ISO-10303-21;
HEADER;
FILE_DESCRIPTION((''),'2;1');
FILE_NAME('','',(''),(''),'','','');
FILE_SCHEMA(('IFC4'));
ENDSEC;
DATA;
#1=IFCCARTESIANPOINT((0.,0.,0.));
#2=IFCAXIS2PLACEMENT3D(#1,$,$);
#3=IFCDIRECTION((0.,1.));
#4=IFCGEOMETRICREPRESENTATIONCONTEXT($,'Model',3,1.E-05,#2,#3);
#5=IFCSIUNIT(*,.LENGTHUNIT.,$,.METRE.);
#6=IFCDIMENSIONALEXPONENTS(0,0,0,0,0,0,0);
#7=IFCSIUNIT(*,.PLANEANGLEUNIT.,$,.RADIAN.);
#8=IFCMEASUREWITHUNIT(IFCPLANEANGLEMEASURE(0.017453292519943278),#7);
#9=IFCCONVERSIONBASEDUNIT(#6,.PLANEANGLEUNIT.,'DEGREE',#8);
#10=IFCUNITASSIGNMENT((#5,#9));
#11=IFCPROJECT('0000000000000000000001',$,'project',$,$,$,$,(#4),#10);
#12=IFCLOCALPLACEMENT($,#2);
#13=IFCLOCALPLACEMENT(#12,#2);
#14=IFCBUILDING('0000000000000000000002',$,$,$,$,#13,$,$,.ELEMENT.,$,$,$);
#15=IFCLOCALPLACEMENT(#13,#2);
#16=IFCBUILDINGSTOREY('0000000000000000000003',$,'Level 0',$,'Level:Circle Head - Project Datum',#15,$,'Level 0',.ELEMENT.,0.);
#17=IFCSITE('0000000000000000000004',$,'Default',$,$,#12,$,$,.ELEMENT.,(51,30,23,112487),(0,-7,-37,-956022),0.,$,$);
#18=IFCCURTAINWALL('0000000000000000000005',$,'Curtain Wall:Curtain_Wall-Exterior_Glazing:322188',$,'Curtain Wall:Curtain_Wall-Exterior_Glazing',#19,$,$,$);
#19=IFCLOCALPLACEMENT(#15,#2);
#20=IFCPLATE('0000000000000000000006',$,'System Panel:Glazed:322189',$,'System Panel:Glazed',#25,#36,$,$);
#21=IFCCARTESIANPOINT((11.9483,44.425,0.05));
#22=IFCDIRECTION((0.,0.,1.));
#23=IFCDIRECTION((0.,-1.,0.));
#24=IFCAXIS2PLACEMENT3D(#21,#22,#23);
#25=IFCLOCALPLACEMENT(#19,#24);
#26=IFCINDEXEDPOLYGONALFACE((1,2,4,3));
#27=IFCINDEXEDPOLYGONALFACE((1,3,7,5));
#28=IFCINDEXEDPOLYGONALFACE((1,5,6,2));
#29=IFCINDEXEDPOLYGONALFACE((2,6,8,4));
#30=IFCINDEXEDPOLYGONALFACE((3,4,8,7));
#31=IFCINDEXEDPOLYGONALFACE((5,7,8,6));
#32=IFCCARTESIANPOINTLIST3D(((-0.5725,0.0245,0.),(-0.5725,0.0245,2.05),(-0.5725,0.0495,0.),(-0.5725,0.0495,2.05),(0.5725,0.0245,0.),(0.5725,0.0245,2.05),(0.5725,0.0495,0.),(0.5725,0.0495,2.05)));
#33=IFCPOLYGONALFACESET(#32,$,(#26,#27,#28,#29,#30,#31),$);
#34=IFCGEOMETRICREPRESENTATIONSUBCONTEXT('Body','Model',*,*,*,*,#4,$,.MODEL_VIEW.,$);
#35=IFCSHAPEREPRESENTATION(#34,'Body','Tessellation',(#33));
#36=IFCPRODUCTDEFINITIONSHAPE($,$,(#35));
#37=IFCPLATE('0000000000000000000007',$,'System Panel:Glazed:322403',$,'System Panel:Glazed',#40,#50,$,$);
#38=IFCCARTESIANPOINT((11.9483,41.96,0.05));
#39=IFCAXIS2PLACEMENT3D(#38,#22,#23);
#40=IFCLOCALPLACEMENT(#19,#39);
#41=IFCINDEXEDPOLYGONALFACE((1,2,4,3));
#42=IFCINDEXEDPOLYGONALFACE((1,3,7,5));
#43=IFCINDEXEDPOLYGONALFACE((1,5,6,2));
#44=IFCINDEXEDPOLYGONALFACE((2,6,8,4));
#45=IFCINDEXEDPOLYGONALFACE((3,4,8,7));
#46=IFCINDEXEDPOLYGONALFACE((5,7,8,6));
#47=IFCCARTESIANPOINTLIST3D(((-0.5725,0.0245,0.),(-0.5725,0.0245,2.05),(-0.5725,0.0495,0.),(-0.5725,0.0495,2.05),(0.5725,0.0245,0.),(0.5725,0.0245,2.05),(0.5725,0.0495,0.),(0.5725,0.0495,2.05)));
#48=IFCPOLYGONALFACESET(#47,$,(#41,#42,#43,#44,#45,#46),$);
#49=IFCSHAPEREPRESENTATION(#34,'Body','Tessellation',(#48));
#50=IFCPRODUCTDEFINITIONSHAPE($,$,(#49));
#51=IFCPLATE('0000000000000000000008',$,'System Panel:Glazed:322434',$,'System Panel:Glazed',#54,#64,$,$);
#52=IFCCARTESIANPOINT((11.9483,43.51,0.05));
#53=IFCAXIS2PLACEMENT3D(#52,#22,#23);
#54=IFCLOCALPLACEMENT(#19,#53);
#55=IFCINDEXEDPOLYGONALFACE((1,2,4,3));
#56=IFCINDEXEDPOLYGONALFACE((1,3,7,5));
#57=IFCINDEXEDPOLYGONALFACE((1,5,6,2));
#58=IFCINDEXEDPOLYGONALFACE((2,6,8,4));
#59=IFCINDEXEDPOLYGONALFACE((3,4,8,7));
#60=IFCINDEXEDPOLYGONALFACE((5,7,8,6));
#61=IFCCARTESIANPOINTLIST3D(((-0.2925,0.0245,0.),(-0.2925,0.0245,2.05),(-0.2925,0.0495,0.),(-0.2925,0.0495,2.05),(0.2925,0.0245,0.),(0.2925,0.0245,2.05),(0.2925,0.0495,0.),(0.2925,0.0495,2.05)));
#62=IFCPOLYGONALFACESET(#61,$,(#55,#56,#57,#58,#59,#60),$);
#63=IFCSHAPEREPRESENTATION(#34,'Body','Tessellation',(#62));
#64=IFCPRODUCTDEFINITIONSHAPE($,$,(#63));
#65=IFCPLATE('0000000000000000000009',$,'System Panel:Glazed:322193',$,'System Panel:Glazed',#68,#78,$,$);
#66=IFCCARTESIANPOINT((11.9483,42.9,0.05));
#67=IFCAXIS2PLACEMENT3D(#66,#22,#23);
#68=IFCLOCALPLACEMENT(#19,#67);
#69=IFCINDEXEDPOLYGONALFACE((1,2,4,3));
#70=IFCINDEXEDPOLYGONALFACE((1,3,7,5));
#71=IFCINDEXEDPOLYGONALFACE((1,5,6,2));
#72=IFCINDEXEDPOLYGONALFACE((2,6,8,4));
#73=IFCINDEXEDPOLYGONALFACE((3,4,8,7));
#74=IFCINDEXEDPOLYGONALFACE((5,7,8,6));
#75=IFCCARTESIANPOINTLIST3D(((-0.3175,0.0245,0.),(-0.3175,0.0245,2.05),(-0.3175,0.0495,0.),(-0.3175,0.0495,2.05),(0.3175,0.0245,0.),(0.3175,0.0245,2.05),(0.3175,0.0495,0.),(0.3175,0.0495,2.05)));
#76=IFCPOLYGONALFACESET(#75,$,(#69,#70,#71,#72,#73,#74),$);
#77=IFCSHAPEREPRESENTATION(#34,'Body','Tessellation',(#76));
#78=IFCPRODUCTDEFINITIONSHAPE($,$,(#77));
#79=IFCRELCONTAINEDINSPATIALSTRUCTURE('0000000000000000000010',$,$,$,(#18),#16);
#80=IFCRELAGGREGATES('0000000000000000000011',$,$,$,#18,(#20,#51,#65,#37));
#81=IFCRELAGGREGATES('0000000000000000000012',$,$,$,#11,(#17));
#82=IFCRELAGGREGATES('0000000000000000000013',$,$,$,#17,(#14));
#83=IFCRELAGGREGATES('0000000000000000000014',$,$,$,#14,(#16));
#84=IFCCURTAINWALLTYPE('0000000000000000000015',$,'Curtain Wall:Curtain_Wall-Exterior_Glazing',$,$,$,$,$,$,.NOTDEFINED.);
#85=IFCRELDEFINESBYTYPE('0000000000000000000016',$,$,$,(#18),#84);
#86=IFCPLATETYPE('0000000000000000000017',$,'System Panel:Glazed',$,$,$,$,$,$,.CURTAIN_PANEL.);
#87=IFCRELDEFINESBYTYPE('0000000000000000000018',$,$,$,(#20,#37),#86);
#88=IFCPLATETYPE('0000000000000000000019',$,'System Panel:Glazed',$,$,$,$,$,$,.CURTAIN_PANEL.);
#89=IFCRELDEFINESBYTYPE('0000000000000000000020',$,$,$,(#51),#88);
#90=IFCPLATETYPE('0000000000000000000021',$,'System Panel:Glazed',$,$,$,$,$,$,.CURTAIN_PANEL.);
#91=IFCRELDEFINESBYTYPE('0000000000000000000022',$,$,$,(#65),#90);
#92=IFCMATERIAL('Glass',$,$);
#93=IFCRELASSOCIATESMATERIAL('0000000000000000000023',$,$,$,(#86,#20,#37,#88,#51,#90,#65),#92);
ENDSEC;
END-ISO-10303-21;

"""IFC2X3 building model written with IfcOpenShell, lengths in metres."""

from ifc_helpers import new_model, entity, si_unit, converted_unit, direction, frame, origin, origin_2d_with_axis, place, context, subcontext, project, spatial, rectangle, extrude, source, transform, mapped, material, type_object, type_shapes, element, aggregate, save


model = new_model("IFC2X3")

# Units and contexts
model_context = context("Model", 3, precision=1e-05, world=origin(), true_north=direction((0.0, 1.0)))
body_context = subcontext(model_context, "Body", "Model", "MODEL_VIEW")
ifc_project = project(units=[si_unit("LENGTHUNIT", "METRE"), converted_unit("PLANEANGLEUNIT", "DEGREE", entity("IfcPlaneAngleMeasure", 0.017453292519943278), si_unit("PLANEANGLEUNIT", "RADIAN"), dimensions=[0, 0, 0, 0, 0, 0, 0])], contexts=[model_context])

# Site, building, storey
site_placement = place(None, origin())
site = spatial("IfcSite", under=ifc_project, at=site_placement, Name="Default", CompositionType="ELEMENT", RefLatitude=(51, 30, 23, 112487), RefLongitude=(0, -7, -37, -956022), RefElevation=0.0)
building_placement = place(site_placement, origin())
building = spatial("IfcBuilding", under=site, at=building_placement, CompositionType="ELEMENT")
storey_placement = place(building_placement, origin())
storey = spatial("IfcBuildingStorey", under=building, at=storey_placement, Name="Level 0", ObjectType="Level:Circle Head - Project Datum", LongName="Level 0", CompositionType="ELEMENT", Elevation=0.0)

# Curtain wall, plates
curtain_wall_type = type_object("IfcCurtainWallType", Name="Curtain Wall:Curtain_Wall-Exterior_Glazing", PredefinedType="NOTDEFINED")
curtain_wall_placement = place(storey_placement, origin())
curtain_wall = element("IfcCurtainWall", 1, at=curtain_wall_placement, inside=storey, type_object=curtain_wall_type, Name="Curtain Wall:Curtain_Wall-Exterior_Glazing:322188", ObjectType="Curtain Wall:Curtain_Wall-Exterior_Glazing")
ifc_material_1 = material(Name="Glass")
plate_type_1 = type_object("IfcPlateType", Name="System Panel:Glazed", PredefinedType="CURTAIN_PANEL", material=ifc_material_1)
shared_shape_1 = source(origin(), body_context, "Body", "SweptSolid", [
    extrude(rectangle(XDim=0.025, YDim=1.145, at=origin_2d_with_axis()), frame((0.0, 0.037, 0.0), z_axis=(0.0, 0.0, 1.0), x_axis=(0.0, 1.0, 0.0)), (0.0, 0.0, 1.0), 2.05),
])
type_shapes(plate_type_1, [shared_shape_1])
plate_1_placement = place(curtain_wall_placement, frame((11.9483, 44.425, 0.05), z_axis=(0.0, 0.0, 1.0), x_axis=(0.0, -1.0, 0.0)))
plate_1 = element("IfcPlate", 2, at=plate_1_placement, type_object=plate_type_1, material=ifc_material_1, Name="System Panel:Glazed:322189", ObjectType="System Panel:Glazed", context=body_context, shape_type="MappedRepresentation", body=[
    mapped(shared_shape_1, transform((0.0, 0.0, 0.0), scale=1.0)),
])
plate_2_placement = place(curtain_wall_placement, frame((11.9483, 41.96, 0.05), z_axis=(0.0, 0.0, 1.0), x_axis=(0.0, -1.0, 0.0)))
plate_2 = element("IfcPlate", 3, at=plate_2_placement, type_object=plate_type_1, material=ifc_material_1, Name="System Panel:Glazed:322403", ObjectType="System Panel:Glazed", context=body_context, shape_type="MappedRepresentation", body=[
    mapped(shared_shape_1, transform((0.0, 0.0, 0.0), scale=1.0)),
])
plate_type_2 = type_object("IfcPlateType", Name="System Panel:Glazed", PredefinedType="CURTAIN_PANEL", material=ifc_material_1)
shared_shape_2 = source(origin(), body_context, "Body", "SweptSolid", [
    extrude(rectangle(XDim=0.025, YDim=0.585, at=origin_2d_with_axis()), frame((0.0, 0.037, 0.0), z_axis=(0.0, 0.0, 1.0), x_axis=(0.0, 1.0, 0.0)), (0.0, 0.0, 1.0), 2.05),
])
type_shapes(plate_type_2, [shared_shape_2])
plate_3_placement = place(curtain_wall_placement, frame((11.9483, 43.51, 0.05), z_axis=(0.0, 0.0, 1.0), x_axis=(0.0, -1.0, 0.0)))
plate_3 = element("IfcPlate", 4, at=plate_3_placement, type_object=plate_type_2, material=ifc_material_1, Name="System Panel:Glazed:322434", ObjectType="System Panel:Glazed", context=body_context, shape_type="MappedRepresentation", body=[
    mapped(shared_shape_2, transform((0.0, 0.0, 0.0), scale=1.0)),
])
plate_type_3 = type_object("IfcPlateType", Name="System Panel:Glazed", PredefinedType="CURTAIN_PANEL", material=ifc_material_1)
shared_shape_3 = source(origin(), body_context, "Body", "SweptSolid", [
    extrude(rectangle(XDim=0.025, YDim=0.635, at=origin_2d_with_axis()), frame((0.0, 0.037, 0.0), z_axis=(0.0, 0.0, 1.0), x_axis=(0.0, 1.0, 0.0)), (0.0, 0.0, 1.0), 2.05),
])
type_shapes(plate_type_3, [shared_shape_3])
plate_4_placement = place(curtain_wall_placement, frame((11.9483, 42.9, 0.05), z_axis=(0.0, 0.0, 1.0), x_axis=(0.0, -1.0, 0.0)))
plate_4 = element("IfcPlate", 5, at=plate_4_placement, type_object=plate_type_3, material=ifc_material_1, Name="System Panel:Glazed:322193", ObjectType="System Panel:Glazed", context=body_context, shape_type="MappedRepresentation", body=[
    mapped(shared_shape_3, transform((0.0, 0.0, 0.0), scale=1.0)),
])
aggregate(curtain_wall, [plate_1, plate_3, plate_4, plate_2])

save(model, "model.ifc")
